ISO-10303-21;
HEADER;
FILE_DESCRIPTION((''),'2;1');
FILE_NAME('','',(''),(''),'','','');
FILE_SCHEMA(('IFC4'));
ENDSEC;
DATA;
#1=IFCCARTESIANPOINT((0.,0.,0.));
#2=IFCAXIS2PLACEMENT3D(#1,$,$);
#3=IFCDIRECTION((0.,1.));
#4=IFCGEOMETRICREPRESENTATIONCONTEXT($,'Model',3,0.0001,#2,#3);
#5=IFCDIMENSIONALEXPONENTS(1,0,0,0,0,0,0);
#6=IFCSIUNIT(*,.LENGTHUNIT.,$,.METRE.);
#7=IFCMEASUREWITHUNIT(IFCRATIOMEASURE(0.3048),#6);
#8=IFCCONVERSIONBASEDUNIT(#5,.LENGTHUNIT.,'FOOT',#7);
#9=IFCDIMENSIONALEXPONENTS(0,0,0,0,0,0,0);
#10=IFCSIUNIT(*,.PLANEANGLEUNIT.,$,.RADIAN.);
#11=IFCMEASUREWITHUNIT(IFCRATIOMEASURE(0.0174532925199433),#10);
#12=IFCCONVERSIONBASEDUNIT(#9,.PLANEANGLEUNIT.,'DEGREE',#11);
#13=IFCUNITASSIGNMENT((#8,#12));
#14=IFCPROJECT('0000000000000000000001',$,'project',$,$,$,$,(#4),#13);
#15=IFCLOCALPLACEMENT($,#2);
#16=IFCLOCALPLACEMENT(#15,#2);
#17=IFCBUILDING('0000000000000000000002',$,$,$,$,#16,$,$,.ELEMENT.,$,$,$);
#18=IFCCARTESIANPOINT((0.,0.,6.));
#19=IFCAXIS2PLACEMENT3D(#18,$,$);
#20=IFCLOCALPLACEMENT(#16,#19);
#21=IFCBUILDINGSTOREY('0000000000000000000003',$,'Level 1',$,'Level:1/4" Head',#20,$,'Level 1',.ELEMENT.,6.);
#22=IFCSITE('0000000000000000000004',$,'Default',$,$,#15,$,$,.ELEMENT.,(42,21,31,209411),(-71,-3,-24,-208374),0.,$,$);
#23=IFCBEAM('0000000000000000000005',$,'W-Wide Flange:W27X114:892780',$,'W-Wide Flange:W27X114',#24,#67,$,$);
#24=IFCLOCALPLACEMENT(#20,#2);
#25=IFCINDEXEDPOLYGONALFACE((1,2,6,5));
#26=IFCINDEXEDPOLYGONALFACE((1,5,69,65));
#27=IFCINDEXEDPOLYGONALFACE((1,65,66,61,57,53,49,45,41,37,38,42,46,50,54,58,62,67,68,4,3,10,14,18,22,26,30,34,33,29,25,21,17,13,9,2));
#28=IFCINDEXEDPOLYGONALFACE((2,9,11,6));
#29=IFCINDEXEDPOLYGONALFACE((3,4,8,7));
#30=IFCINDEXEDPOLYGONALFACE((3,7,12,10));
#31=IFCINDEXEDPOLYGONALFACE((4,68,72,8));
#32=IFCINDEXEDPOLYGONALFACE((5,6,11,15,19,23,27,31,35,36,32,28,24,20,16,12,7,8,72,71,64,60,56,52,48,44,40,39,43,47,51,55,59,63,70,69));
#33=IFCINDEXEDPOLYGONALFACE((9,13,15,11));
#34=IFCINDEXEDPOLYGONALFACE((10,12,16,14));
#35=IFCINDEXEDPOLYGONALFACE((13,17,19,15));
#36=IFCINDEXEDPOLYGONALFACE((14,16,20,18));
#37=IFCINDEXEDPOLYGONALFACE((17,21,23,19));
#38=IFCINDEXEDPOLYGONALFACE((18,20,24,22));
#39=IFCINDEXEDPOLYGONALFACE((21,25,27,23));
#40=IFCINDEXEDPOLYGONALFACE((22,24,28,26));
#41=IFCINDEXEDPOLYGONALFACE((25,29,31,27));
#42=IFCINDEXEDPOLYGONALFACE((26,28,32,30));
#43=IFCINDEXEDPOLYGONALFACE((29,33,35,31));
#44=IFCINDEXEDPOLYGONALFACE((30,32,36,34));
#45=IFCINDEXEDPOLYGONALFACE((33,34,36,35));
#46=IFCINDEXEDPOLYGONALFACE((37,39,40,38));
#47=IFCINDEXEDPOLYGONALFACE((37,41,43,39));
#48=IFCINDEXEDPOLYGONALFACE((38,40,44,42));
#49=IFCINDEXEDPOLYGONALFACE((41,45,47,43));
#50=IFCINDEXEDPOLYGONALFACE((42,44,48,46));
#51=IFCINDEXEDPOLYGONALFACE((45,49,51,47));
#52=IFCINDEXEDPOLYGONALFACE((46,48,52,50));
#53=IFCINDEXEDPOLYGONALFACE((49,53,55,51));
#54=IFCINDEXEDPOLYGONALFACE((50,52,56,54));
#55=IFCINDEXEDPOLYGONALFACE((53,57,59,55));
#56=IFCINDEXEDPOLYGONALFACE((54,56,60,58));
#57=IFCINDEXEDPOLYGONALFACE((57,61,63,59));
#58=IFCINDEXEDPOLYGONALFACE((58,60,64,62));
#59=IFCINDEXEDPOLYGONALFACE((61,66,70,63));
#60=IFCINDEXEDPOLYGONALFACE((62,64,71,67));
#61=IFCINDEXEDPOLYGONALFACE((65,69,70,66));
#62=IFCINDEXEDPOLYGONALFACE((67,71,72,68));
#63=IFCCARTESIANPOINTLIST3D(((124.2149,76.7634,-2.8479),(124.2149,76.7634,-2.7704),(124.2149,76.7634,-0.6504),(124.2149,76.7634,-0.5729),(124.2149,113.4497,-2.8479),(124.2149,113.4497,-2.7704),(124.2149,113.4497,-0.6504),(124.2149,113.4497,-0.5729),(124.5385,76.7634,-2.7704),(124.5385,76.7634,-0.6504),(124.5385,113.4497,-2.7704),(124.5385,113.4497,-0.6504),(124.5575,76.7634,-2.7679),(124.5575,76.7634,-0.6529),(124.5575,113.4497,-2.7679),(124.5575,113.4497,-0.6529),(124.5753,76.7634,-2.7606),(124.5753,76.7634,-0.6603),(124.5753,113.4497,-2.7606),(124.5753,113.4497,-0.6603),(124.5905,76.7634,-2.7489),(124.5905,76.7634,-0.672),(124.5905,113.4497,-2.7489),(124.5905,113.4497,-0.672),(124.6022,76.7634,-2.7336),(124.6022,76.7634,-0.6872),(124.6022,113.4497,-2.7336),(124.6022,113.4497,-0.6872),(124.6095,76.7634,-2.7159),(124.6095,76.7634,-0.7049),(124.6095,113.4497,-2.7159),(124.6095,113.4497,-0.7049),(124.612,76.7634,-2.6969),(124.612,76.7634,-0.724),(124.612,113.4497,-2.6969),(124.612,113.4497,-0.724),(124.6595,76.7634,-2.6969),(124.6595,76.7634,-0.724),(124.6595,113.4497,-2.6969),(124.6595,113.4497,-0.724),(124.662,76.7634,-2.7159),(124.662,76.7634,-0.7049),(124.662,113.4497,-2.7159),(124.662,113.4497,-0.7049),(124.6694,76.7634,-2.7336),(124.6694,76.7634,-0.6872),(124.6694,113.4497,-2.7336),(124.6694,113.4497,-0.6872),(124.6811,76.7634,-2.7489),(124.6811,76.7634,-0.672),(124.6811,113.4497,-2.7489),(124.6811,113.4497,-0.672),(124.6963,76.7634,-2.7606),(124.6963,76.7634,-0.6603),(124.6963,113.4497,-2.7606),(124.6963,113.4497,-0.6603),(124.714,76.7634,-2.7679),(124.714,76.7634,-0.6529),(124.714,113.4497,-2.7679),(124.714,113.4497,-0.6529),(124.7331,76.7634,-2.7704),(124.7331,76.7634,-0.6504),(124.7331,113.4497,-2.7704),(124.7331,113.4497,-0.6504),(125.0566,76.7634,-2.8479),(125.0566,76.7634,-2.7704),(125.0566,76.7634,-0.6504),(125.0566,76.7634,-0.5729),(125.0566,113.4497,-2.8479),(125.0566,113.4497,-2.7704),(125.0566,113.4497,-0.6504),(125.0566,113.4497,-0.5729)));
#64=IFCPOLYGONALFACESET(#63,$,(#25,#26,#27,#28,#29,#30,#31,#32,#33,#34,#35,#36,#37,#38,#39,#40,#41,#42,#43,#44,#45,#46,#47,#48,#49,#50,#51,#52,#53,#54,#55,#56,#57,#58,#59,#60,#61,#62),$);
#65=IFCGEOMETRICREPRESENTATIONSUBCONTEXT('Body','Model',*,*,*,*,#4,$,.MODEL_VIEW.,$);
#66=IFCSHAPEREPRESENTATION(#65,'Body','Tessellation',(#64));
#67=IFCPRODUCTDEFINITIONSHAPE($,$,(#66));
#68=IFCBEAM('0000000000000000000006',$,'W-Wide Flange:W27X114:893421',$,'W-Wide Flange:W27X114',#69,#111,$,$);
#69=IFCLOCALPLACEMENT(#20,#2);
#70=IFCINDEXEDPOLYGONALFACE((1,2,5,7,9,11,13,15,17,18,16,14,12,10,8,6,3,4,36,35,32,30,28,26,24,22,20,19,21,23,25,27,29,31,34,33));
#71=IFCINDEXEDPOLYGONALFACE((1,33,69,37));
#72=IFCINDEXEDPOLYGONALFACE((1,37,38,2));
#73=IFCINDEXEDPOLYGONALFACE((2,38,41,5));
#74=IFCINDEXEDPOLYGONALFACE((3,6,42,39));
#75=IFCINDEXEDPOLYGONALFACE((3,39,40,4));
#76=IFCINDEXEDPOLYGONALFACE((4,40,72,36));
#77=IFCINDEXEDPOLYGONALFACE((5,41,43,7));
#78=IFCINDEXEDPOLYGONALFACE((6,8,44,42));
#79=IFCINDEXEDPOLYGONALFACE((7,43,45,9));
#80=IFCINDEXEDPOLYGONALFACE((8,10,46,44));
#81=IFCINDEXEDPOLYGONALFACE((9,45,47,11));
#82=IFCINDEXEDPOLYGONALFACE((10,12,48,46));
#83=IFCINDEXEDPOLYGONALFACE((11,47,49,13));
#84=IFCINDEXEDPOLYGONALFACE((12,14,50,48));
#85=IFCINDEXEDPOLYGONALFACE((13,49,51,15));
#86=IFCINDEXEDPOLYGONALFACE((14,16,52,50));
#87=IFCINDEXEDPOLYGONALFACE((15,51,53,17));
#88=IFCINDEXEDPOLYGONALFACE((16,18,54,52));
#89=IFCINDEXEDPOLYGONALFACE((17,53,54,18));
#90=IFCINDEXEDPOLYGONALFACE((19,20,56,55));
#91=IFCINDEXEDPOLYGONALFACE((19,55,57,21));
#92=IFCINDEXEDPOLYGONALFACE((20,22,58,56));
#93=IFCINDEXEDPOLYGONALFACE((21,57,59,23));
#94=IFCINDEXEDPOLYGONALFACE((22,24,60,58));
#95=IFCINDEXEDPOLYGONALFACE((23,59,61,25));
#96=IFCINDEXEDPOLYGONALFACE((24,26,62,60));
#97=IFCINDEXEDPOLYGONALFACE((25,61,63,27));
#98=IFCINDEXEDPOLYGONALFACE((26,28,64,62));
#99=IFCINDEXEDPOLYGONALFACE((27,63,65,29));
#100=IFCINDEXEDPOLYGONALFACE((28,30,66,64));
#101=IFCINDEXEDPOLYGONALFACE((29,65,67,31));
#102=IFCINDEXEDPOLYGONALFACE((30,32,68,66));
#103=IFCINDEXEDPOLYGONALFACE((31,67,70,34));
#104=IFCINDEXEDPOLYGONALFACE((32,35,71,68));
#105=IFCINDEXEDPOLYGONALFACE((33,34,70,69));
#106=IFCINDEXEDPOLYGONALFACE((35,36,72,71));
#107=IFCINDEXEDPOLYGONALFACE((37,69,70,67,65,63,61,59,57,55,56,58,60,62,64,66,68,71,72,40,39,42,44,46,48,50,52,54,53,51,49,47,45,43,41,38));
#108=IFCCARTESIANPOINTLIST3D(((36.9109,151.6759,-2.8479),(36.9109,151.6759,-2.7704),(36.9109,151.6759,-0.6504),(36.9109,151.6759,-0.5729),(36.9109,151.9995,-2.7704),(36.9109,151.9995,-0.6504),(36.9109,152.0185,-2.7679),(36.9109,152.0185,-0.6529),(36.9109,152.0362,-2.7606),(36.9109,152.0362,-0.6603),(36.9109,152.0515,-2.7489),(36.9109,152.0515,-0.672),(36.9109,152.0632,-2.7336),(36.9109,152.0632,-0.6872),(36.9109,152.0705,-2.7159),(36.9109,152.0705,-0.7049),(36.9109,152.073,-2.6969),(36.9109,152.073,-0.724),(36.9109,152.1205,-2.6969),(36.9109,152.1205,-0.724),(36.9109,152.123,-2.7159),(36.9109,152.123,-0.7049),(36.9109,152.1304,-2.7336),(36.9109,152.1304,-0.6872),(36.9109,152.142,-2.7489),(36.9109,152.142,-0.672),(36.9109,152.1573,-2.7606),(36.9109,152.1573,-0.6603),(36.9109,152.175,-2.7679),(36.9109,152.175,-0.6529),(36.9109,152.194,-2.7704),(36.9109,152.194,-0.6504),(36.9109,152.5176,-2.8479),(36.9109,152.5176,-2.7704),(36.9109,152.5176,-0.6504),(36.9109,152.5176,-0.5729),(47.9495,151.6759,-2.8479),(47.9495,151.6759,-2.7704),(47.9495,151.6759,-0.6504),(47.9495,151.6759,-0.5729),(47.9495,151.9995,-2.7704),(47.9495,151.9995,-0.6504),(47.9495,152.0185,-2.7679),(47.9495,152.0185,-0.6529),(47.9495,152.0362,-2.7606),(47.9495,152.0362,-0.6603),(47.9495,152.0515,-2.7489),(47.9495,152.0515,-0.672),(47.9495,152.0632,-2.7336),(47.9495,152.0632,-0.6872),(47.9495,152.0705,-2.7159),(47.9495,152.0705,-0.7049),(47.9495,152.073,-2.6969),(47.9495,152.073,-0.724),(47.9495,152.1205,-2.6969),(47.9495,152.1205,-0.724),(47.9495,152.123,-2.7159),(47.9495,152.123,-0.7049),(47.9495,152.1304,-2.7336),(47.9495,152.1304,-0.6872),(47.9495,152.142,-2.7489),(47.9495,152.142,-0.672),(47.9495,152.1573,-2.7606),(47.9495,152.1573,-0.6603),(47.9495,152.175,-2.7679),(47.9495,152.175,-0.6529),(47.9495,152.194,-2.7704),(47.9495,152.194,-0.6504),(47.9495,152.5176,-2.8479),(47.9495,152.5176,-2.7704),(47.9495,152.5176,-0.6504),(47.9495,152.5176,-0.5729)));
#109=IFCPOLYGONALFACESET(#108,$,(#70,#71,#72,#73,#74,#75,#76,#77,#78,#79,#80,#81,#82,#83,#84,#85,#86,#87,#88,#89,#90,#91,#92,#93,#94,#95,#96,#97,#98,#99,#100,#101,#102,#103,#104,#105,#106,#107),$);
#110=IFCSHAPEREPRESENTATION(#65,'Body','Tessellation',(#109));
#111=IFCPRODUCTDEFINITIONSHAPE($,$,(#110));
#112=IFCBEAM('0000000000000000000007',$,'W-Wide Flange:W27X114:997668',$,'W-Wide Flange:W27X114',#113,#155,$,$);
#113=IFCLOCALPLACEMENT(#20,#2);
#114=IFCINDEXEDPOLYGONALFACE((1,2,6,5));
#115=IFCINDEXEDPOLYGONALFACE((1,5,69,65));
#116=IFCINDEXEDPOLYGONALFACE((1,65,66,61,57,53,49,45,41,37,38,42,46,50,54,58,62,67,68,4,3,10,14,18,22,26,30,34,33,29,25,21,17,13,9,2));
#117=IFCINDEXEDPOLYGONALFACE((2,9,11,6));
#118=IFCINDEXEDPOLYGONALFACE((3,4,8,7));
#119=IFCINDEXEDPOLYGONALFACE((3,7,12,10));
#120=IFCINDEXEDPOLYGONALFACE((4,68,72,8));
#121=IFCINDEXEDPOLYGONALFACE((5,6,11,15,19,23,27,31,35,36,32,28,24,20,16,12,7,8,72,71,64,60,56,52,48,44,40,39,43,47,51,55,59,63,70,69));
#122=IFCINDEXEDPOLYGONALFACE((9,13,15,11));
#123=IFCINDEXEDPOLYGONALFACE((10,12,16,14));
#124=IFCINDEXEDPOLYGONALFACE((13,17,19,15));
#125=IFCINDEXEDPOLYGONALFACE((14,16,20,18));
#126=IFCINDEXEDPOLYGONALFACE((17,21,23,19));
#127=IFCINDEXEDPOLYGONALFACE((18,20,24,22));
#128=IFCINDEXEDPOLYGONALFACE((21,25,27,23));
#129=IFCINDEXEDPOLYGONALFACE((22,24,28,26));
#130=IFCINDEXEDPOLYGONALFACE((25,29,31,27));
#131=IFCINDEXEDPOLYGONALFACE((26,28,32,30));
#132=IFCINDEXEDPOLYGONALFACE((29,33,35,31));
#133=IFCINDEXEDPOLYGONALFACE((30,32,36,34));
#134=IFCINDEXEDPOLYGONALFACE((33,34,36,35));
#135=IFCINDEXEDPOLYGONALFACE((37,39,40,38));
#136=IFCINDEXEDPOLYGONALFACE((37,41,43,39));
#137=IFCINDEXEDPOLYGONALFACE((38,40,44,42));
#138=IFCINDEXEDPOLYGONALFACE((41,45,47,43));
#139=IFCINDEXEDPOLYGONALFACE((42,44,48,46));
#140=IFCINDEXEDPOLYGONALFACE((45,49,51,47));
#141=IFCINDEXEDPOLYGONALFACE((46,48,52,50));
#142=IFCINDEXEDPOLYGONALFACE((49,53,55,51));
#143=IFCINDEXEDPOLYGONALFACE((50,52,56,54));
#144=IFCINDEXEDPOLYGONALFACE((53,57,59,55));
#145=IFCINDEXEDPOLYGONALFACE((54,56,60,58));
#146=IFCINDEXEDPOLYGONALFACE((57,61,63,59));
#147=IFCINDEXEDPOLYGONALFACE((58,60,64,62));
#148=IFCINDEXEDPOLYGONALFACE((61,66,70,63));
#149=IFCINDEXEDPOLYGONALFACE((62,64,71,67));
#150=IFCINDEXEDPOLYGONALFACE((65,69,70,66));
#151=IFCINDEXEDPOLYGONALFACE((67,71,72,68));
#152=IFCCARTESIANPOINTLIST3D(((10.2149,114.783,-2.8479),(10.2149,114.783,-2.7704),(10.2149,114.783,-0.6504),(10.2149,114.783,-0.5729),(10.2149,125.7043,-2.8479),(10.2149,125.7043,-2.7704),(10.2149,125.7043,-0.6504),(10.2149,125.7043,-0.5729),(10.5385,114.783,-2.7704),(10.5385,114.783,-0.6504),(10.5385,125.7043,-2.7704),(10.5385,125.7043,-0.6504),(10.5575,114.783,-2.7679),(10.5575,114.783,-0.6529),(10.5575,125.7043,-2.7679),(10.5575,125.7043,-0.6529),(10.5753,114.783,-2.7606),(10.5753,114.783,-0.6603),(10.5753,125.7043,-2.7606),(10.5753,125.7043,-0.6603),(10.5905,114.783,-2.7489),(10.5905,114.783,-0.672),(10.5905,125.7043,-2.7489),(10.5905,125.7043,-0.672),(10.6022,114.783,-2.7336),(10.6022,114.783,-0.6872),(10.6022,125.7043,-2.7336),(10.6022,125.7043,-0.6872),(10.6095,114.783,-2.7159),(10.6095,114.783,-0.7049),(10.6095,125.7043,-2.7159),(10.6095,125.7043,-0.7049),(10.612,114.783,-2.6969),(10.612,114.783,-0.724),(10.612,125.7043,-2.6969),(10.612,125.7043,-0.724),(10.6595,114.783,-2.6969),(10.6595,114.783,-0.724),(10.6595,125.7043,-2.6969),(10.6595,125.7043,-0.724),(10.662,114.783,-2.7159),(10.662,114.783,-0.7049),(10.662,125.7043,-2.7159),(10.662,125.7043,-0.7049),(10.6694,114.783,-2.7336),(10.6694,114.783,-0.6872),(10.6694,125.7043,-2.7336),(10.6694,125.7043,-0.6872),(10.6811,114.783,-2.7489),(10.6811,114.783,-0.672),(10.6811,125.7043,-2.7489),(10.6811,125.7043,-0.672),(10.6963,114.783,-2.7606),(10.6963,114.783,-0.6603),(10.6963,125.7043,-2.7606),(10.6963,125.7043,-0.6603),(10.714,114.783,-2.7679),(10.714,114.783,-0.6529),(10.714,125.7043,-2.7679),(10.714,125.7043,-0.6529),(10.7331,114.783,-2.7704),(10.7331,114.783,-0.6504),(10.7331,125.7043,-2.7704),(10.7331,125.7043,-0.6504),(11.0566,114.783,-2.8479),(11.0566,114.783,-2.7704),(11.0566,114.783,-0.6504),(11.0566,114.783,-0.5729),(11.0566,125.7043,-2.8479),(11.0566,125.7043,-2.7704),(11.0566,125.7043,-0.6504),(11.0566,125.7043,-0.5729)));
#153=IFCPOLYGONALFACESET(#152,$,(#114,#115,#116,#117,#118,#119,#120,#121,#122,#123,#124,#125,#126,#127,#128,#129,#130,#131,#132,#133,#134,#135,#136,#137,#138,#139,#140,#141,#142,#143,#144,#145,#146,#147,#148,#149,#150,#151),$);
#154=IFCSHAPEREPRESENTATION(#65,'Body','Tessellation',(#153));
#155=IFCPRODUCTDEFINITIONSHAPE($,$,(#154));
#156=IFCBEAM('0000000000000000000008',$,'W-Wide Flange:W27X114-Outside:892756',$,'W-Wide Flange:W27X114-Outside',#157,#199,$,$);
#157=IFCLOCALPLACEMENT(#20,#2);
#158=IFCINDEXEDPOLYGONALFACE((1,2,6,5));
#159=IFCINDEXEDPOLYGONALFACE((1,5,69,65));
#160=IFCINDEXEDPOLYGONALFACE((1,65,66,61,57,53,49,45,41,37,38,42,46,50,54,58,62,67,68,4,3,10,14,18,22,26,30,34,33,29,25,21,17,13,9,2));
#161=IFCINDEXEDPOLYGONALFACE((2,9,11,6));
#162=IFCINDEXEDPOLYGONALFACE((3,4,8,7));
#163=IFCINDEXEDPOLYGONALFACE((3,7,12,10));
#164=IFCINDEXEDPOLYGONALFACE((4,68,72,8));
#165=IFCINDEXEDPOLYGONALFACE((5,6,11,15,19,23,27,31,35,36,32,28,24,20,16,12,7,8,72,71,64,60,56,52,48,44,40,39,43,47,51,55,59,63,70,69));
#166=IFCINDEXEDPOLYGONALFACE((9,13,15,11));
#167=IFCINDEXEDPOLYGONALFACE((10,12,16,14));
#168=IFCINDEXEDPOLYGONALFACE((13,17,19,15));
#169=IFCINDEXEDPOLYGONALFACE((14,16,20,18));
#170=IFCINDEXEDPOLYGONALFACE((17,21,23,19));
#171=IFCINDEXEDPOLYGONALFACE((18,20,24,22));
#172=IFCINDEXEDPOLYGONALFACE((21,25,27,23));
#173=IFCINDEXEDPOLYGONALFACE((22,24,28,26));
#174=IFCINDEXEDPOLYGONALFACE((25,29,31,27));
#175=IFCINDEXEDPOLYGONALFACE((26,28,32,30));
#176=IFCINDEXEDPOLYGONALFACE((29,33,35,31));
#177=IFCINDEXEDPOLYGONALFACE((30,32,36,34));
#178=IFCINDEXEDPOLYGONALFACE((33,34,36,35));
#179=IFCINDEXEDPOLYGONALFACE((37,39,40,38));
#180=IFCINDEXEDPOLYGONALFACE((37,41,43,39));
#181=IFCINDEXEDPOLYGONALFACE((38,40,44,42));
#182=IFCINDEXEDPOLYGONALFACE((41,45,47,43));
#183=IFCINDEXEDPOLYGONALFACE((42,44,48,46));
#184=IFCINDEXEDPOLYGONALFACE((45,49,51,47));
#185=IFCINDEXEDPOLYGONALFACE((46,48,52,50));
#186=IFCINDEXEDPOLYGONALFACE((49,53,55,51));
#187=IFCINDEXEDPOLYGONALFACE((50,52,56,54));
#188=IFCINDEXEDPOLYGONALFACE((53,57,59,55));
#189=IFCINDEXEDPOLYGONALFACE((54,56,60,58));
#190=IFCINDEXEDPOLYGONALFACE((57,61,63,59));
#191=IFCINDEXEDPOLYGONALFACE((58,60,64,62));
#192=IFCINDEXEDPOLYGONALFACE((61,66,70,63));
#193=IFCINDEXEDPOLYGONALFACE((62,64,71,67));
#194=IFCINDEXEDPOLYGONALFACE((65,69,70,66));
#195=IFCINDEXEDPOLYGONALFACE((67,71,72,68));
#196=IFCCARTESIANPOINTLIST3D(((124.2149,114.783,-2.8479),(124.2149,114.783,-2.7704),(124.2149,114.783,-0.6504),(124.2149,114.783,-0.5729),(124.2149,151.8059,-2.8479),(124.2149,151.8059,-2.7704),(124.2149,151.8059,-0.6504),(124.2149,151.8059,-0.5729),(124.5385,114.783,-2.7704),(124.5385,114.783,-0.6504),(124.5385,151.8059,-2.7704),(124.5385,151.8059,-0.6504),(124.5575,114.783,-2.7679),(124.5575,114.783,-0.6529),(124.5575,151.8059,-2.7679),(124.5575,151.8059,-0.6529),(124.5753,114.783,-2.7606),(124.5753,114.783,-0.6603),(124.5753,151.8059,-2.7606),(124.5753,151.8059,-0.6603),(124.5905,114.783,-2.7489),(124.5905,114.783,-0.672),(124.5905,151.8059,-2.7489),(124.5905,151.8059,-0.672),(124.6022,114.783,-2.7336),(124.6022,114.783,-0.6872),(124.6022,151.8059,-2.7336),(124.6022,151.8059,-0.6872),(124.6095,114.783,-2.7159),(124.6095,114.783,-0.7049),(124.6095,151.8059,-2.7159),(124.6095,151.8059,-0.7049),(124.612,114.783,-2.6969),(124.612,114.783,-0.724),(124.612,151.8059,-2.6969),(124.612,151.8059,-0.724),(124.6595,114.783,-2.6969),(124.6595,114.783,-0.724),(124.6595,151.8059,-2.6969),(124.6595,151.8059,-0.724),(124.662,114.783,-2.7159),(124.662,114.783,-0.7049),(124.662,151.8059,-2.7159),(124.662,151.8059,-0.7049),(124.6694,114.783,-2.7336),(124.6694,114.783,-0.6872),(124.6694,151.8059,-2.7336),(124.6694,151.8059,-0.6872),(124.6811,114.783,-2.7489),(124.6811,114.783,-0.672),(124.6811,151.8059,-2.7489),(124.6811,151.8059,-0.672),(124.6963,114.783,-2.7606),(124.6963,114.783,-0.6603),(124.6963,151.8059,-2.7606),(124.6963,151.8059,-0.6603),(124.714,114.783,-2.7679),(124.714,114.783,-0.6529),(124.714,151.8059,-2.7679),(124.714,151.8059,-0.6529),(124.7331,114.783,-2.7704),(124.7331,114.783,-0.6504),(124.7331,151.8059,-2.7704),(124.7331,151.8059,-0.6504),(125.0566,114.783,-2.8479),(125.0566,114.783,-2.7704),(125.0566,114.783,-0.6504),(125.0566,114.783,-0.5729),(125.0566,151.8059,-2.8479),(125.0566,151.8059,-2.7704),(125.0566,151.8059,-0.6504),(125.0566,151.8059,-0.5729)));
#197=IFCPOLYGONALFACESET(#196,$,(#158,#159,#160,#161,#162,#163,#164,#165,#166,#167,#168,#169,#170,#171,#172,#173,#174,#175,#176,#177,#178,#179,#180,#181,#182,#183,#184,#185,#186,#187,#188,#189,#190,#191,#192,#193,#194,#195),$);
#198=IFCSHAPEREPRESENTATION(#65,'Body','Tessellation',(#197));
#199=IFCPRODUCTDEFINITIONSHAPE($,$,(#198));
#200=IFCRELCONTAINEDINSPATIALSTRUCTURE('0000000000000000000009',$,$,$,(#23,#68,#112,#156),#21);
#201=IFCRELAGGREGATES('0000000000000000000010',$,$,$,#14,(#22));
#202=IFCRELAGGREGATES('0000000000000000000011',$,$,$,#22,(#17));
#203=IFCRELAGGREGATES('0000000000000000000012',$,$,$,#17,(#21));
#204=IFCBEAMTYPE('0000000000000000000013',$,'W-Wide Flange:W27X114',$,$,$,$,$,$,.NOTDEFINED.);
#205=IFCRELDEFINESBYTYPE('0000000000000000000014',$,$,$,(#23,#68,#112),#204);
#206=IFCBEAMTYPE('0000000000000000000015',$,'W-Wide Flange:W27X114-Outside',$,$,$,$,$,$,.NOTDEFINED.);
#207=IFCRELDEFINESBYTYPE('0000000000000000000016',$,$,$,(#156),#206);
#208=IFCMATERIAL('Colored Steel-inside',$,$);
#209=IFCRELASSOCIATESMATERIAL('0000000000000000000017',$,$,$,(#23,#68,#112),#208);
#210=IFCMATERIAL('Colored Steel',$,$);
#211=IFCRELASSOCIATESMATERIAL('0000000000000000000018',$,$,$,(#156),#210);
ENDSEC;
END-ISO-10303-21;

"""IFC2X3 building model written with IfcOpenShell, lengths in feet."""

from ifc_helpers import new_model, entity, si_unit, converted_unit, direction, frame, frame_2d, origin, place, context, subcontext, project, spatial, i_section, extrude, material, type_object, element, save


model = new_model("IFC2X3")

# Units and contexts
model_context = context("Model", 3, precision=0.0001, world=origin(), true_north=direction((0.0, 1.0)))
body_context = subcontext(model_context, "Body", "Model", "MODEL_VIEW")
ifc_project = project(units=[converted_unit("LENGTHUNIT", "FOOT", entity("IfcRatioMeasure", 0.3048), si_unit("LENGTHUNIT", "METRE"), dimensions=[1, 0, 0, 0, 0, 0, 0]), converted_unit("PLANEANGLEUNIT", "DEGREE", entity("IfcRatioMeasure", 0.0174532925199433), si_unit("PLANEANGLEUNIT", "RADIAN"), dimensions=[0, 0, 0, 0, 0, 0, 0])], contexts=[model_context])

# Site, building, storey
site_placement = place(None, origin())
site = spatial("IfcSite", under=ifc_project, at=site_placement, Name="Default", CompositionType="ELEMENT", RefLatitude=(42, 21, 31, 209411), RefLongitude=(-71, -3, -24, -208374), RefElevation=0.0)
building_placement = place(site_placement, origin())
building = spatial("IfcBuilding", under=site, at=building_placement, CompositionType="ELEMENT")
storey_placement = place(building_placement, frame((0.0, 0.0, 6.0)))
storey = spatial("IfcBuildingStorey", under=building, at=storey_placement, Name="Level 1", ObjectType="Level:1/4\" Head", LongName="Level 1", CompositionType="ELEMENT", Elevation=6.0)

# Shared definitions
ifc_material_1 = material(Name="Colored Steel-inside")

# Beams
beam_type_1 = type_object("IfcBeamType", Name="W-Wide Flange:W27X114", PredefinedType="NOTDEFINED")
beam_1_placement = place(storey_placement, frame((124.6358, 114.0968, 0.0), z_axis=(0.0, 0.0, 1.0), x_axis=(0.0, -1.0, 0.0)))
element("IfcBeam", 1, at=beam_1_placement, inside=storey, type_object=beam_type_1, material=ifc_material_1, Name="W-Wide Flange:W27X114:892780", ObjectType="W-Wide Flange:W27X114", context=body_context, shape_type="SweptSolid", body=[
    extrude(i_section(OverallWidth=0.8417, OverallDepth=2.275, WebThickness=0.0475, FlangeThickness=0.0775, FilletRadius=0.0735, at=frame_2d((0.0, 0.0), x_axis=(0.0, 1.0))), frame((0.6471, 0.0, -1.7104), z_axis=(1.0, 0.0, 0.0), x_axis=(0.0, 0.0, -1.0)), (0.0, 0.0, 1.0), 36.6863),
])
beam_2_placement = place(storey_placement, frame((10.6358, 152.0968, 0.0)))
element("IfcBeam", 2, at=beam_2_placement, inside=storey, type_object=beam_type_1, material=ifc_material_1, Name="W-Wide Flange:W27X114:893421", ObjectType="W-Wide Flange:W27X114", context=body_context, shape_type="SweptSolid", body=[
    extrude(i_section(OverallWidth=0.8417, OverallDepth=2.275, WebThickness=0.0475, FlangeThickness=0.0775, FilletRadius=0.0735, at=frame_2d((0.0, 0.0), x_axis=(0.0, 1.0))), frame((26.2752, 0.0, -1.7104), z_axis=(1.0, 0.0, 0.0), x_axis=(0.0, 0.0, -1.0)), (0.0, 0.0, 1.0), 11.0386),
])
beam_3_placement = place(storey_placement, frame((10.6358, 139.4497, 0.0), z_axis=(0.0, 0.0, 1.0), x_axis=(0.0, -1.0, 0.0)))
element("IfcBeam", 3, at=beam_3_placement, inside=storey, type_object=beam_type_1, material=ifc_material_1, Name="W-Wide Flange:W27X114:997668", ObjectType="W-Wide Flange:W27X114", context=body_context, shape_type="SweptSolid", body=[
    extrude(i_section(OverallWidth=0.8417, OverallDepth=2.275, WebThickness=0.0475, FlangeThickness=0.0775, FilletRadius=0.0735, at=frame_2d((0.0, 0.0), x_axis=(0.0, 1.0))), frame((13.7454, 0.0, -1.7104), z_axis=(1.0, 0.0, 0.0), x_axis=(0.0, 0.0, -1.0)), (0.0, 0.0, 1.0), 10.9213),
])
ifc_material_2 = material(Name="Colored Steel")
beam_type_2 = type_object("IfcBeamType", Name="W-Wide Flange:W27X114-Outside", PredefinedType="NOTDEFINED")
beam_4_placement = place(storey_placement, frame((124.6358, 152.0968, 0.0), z_axis=(0.0, 0.0, 1.0), x_axis=(0.0, -1.0, 0.0)))
element("IfcBeam", 4, at=beam_4_placement, inside=storey, type_object=beam_type_2, material=ifc_material_2, Name="W-Wide Flange:W27X114-Outside:892756", ObjectType="W-Wide Flange:W27X114-Outside", context=body_context, shape_type="SweptSolid", body=[
    extrude(i_section(OverallWidth=0.8417, OverallDepth=2.275, WebThickness=0.0475, FlangeThickness=0.0775, FilletRadius=0.0735, at=frame_2d((0.0, 0.0), x_axis=(0.0, 1.0))), frame((0.2908, 0.0, -1.7104), z_axis=(1.0, 0.0, 0.0), x_axis=(0.0, 0.0, -1.0)), (0.0, 0.0, 1.0), 37.0229),
])

save(model, "model.ifc")
